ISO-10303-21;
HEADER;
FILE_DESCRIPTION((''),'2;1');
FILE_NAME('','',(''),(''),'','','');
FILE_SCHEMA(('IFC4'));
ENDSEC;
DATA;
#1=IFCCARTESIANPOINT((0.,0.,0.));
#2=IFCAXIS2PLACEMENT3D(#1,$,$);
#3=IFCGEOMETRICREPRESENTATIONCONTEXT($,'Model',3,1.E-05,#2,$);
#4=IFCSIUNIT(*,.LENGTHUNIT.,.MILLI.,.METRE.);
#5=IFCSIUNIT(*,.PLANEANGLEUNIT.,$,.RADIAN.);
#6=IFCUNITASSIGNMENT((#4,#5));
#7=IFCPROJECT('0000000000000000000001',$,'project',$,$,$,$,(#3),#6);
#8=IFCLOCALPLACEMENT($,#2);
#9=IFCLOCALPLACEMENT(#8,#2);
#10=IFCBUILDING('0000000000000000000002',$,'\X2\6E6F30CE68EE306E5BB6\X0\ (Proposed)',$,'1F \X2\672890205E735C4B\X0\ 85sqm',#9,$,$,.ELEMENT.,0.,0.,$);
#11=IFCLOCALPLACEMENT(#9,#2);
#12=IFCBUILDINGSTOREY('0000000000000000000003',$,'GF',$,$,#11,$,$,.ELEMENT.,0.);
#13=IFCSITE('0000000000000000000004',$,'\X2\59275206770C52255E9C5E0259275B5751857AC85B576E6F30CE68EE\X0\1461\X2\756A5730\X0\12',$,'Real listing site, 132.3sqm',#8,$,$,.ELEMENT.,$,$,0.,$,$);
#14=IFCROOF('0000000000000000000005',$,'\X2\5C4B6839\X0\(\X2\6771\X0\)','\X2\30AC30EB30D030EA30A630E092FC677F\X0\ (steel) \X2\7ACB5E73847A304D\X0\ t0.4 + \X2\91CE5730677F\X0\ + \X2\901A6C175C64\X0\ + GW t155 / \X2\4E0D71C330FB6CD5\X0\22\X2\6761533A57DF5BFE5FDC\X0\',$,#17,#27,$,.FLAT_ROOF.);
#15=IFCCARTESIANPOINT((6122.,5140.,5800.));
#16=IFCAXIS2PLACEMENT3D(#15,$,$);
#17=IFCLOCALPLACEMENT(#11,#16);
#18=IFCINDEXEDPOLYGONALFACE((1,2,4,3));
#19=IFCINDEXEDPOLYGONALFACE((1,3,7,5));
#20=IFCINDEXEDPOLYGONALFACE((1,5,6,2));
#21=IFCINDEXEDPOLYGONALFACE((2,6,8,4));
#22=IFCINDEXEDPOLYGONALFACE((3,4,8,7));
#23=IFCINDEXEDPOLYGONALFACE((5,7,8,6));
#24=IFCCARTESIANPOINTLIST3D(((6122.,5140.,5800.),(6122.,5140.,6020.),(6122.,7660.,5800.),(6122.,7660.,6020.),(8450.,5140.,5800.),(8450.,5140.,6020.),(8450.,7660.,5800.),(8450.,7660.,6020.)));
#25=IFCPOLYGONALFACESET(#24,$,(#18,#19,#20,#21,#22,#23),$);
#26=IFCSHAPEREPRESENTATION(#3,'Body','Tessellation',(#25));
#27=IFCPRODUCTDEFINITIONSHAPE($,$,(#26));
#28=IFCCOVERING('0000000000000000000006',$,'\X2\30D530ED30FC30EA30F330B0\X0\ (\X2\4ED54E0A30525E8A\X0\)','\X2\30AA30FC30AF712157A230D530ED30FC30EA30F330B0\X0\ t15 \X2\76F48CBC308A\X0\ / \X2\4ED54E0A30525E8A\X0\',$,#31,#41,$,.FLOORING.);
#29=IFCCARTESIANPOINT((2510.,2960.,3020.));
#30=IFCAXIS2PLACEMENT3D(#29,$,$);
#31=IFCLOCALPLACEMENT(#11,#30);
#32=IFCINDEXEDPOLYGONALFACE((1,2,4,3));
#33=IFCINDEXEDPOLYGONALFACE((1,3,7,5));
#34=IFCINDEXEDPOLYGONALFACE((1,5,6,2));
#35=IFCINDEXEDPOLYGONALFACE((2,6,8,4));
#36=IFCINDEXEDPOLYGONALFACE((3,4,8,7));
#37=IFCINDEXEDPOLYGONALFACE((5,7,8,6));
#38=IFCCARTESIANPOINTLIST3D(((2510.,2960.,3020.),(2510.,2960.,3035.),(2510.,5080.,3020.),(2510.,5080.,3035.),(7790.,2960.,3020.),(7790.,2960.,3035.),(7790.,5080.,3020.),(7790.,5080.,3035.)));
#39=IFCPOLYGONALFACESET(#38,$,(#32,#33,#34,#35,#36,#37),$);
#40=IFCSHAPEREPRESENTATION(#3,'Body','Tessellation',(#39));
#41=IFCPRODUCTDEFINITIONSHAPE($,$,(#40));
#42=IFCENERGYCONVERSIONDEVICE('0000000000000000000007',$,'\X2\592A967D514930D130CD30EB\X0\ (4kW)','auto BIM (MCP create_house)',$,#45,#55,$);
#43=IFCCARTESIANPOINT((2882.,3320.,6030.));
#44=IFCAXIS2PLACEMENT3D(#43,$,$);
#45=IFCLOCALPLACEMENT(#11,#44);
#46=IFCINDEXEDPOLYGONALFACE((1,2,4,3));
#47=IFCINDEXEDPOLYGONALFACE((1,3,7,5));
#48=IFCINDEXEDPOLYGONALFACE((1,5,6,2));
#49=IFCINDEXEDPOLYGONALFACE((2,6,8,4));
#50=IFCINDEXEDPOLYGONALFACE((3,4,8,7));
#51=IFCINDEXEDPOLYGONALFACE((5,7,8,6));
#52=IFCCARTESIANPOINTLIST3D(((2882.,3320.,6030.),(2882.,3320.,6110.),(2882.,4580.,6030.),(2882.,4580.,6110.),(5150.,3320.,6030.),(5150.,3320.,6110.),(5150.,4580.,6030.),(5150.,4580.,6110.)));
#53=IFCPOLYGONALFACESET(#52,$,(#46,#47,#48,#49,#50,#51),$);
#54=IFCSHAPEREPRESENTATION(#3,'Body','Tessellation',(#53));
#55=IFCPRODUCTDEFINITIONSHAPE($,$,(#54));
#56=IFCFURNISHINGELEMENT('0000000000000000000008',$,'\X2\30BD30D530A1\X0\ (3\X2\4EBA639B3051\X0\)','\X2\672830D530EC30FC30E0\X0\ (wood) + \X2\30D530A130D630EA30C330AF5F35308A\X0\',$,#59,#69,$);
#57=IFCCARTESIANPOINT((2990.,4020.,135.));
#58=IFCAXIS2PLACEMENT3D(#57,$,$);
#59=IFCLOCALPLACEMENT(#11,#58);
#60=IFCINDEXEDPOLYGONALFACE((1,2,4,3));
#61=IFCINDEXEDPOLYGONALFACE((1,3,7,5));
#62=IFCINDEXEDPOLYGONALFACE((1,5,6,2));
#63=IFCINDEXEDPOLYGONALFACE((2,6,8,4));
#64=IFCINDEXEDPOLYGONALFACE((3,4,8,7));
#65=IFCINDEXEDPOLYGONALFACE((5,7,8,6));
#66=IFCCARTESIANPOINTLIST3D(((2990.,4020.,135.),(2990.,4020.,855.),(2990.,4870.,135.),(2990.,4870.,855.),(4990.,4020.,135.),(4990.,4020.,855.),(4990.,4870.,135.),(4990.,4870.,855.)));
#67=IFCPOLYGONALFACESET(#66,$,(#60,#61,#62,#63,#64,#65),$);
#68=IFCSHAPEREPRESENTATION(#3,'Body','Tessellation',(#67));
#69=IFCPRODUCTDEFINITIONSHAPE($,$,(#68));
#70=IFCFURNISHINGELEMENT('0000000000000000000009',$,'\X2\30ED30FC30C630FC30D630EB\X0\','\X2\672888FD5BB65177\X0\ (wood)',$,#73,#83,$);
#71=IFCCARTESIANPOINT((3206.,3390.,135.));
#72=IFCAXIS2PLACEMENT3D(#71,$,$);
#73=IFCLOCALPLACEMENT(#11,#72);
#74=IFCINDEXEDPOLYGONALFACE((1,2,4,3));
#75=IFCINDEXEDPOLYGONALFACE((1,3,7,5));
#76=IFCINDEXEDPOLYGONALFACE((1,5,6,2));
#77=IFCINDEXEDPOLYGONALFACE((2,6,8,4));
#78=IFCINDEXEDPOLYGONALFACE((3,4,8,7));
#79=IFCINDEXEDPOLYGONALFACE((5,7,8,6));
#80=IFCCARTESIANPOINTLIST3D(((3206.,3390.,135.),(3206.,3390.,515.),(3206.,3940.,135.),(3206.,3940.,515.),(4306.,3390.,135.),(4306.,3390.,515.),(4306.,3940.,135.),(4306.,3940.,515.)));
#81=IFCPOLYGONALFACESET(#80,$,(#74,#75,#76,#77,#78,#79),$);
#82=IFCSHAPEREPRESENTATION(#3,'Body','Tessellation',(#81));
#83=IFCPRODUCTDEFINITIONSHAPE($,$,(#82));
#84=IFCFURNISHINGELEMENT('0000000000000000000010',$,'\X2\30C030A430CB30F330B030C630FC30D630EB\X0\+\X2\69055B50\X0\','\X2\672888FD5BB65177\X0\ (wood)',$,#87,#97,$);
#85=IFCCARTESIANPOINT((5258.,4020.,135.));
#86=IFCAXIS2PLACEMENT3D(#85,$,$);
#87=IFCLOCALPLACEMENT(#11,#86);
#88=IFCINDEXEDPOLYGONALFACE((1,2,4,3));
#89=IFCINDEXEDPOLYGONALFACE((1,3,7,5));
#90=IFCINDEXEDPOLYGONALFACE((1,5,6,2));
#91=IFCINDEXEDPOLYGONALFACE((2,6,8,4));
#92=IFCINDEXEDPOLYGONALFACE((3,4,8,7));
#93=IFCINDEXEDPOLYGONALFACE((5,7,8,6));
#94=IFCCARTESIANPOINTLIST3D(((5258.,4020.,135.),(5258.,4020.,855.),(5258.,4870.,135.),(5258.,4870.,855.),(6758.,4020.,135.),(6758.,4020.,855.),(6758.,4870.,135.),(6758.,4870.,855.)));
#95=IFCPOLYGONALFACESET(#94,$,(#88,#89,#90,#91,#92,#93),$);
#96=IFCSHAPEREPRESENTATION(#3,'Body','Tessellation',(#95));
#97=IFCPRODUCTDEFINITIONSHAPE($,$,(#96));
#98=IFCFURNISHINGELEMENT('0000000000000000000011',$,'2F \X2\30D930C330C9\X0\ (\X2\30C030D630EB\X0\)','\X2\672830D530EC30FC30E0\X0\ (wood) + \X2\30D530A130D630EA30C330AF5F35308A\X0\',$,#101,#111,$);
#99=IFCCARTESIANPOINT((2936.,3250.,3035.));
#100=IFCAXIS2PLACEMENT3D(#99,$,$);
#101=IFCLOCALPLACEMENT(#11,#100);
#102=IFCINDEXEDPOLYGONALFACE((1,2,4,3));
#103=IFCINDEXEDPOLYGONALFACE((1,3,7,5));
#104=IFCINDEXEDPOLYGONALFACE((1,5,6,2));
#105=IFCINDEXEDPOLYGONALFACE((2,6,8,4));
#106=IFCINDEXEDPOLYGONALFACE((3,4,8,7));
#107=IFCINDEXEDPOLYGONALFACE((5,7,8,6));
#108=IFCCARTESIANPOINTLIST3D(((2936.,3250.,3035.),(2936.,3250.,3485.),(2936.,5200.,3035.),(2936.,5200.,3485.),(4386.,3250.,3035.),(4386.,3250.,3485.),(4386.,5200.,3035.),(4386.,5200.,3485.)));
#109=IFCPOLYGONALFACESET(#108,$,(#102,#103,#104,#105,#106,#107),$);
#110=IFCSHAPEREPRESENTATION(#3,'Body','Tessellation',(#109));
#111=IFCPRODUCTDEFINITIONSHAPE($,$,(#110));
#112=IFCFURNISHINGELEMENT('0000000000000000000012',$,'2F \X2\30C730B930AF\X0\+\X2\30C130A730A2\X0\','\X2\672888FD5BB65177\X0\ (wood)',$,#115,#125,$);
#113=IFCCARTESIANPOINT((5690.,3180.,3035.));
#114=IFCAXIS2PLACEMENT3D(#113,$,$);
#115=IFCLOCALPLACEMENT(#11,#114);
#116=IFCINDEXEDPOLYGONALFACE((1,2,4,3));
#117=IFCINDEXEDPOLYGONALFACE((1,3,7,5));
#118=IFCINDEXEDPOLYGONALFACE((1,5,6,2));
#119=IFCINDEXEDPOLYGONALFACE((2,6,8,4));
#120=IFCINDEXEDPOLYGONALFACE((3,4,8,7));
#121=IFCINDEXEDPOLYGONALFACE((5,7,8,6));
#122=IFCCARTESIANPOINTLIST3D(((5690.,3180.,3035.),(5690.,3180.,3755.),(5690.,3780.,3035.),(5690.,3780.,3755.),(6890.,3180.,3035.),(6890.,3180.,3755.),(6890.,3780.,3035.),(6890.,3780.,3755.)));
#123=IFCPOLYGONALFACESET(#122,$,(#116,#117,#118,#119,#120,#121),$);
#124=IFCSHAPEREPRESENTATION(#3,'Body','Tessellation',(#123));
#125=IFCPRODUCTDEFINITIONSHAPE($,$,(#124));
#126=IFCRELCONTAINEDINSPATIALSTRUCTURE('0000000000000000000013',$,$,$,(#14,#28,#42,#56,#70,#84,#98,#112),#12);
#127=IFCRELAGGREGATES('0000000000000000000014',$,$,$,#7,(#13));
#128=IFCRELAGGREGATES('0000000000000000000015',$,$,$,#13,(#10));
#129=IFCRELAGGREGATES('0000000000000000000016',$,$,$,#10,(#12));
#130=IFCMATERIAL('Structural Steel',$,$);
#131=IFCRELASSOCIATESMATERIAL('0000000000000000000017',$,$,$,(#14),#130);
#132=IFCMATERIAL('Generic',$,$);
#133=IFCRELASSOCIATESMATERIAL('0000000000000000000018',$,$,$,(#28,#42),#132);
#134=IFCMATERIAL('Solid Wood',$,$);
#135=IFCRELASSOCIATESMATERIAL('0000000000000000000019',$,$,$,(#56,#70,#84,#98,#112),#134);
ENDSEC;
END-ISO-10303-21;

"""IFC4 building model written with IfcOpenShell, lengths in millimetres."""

from ifc_helpers import new_model, si_unit, frame, frame_2d, origin, place, context, project, spatial, rectangle, extrude, material, element, save


model = new_model("IFC4")

# Units and contexts
model_context = context("Model", 3, precision=1e-05, world=origin())
ifc_project = project(units=[si_unit("LENGTHUNIT", "METRE", prefix="MILLI"), si_unit("PLANEANGLEUNIT", "RADIAN")], contexts=[model_context])

# Site, building, storey
site_placement = place(None, origin())
site = spatial("IfcSite", under=ifc_project, at=site_placement, Name="大分県別府市大字内竈字湯ノ森1461番地12", ObjectType="Real listing site, 132.3sqm", CompositionType="ELEMENT", RefElevation=0.0)
building_placement = place(site_placement, origin())
building = spatial("IfcBuilding", under=site, at=building_placement, Name="湯ノ森の家 (Proposed)", ObjectType="1F 木造平屋 85sqm", CompositionType="ELEMENT", ElevationOfRefHeight=0.0, ElevationOfTerrain=0.0)
storey_placement = place(building_placement, origin())
storey = spatial("IfcBuildingStorey", under=building, at=storey_placement, Name="GF", CompositionType="ELEMENT", Elevation=0.0)

# Shared definitions
ifc_material_1 = material(Name="Solid Wood")

# Roof
ifc_material_2 = material(Name="Structural Steel")
roof_1_placement = place(storey_placement, frame((6122.0, 5140.0, 5800.0)))
element("IfcRoof", 1, at=roof_1_placement, inside=storey, material=ifc_material_2, Name="屋根(東)", Description="ガルバリウム鋼板 (steel) 立平葺き t0.4 + 野地板 + 通気層 + GW t155 / 不燃・法22条区域対応", PredefinedType="FLAT_ROOF", context=model_context, shape_type="SweptSolid", body=[
    extrude(rectangle(XDim=2328.0, YDim=2520.0, at=frame_2d((1164.0, 1260.0))), frame((6122.0, 5140.0, 5800.0)), (0.0, 0.0, 1.0), 220.0),
])

# Covering
ifc_material_3 = material(Name="Generic")
covering_placement = place(storey_placement, frame((2510.0, 2960.0, 3020.0)))
element("IfcCovering", 2, at=covering_placement, inside=storey, material=ifc_material_3, Name="フローリング (仕上げ床)", Description="オーク無垢フローリング t15 直貼り / 仕上げ床", PredefinedType="FLOORING", context=model_context, shape_type="SweptSolid", body=[
    extrude(rectangle(XDim=5280.0, YDim=2120.0, at=frame_2d((2640.0, 1060.0))), frame((2510.0, 2960.0, 3020.0)), (0.0, 0.0, 1.0), 15.0),
])

# Energy conversion device
energy_conversion_device_placement = place(storey_placement, frame((2882.0, 3320.0, 6030.0)))
element("IfcEnergyConversionDevice", 3, at=energy_conversion_device_placement, inside=storey, material=ifc_material_3, Name="太陽光パネル (4kW)", Description="auto BIM (MCP create_house)", context=model_context, shape_type="SweptSolid", body=[
    extrude(rectangle(XDim=2268.0, YDim=1260.0, at=frame_2d((1134.0, 630.0))), frame((2882.0, 3320.0, 6030.0)), (0.0, 0.0, 1.0), 80.0),
])

# Furnishing elements
furnishing_1_placement = place(storey_placement, frame((2990.0, 4020.0, 135.0)))
element("IfcFurnishingElement", 4, at=furnishing_1_placement, inside=storey, material=ifc_material_1, Name="ソファ (3人掛け)", Description="木フレーム (wood) + ファブリック張り", context=model_context, shape_type="SweptSolid", body=[
    extrude(rectangle(XDim=2000.0, YDim=850.0, at=frame_2d((1000.0, 425.0))), frame((2990.0, 4020.0, 135.0)), (0.0, 0.0, 1.0), 720.0),
])
furnishing_2_placement = place(storey_placement, frame((3206.0, 3390.0, 135.0)))
element("IfcFurnishingElement", 5, at=furnishing_2_placement, inside=storey, material=ifc_material_1, Name="ローテーブル", Description="木製家具 (wood)", context=model_context, shape_type="SweptSolid", body=[
    extrude(rectangle(XDim=1100.0, YDim=550.0, at=frame_2d((550.0, 275.0))), frame((3206.0, 3390.0, 135.0)), (0.0, 0.0, 1.0), 380.0),
])
furnishing_3_placement = place(storey_placement, frame((5258.0, 4020.0, 135.0)))
element("IfcFurnishingElement", 6, at=furnishing_3_placement, inside=storey, material=ifc_material_1, Name="ダイニングテーブル+椅子", Description="木製家具 (wood)", context=model_context, shape_type="SweptSolid", body=[
    extrude(rectangle(XDim=1500.0, YDim=850.0, at=frame_2d((750.0, 425.0))), frame((5258.0, 4020.0, 135.0)), (0.0, 0.0, 1.0), 720.0),
])
furnishing_4_placement = place(storey_placement, frame((2936.0, 3250.0, 3035.0)))
element("IfcFurnishingElement", 7, at=furnishing_4_placement, inside=storey, material=ifc_material_1, Name="2F ベッド (ダブル)", Description="木フレーム (wood) + ファブリック張り", context=model_context, shape_type="SweptSolid", body=[
    extrude(rectangle(XDim=1450.0, YDim=1950.0, at=frame_2d((725.0, 975.0))), frame((2936.0, 3250.0, 3035.0)), (0.0, 0.0, 1.0), 450.0),
])
furnishing_5_placement = place(storey_placement, frame((5690.0, 3180.0, 3035.0)))
element("IfcFurnishingElement", 8, at=furnishing_5_placement, inside=storey, material=ifc_material_1, Name="2F デスク+チェア", Description="木製家具 (wood)", context=model_context, shape_type="SweptSolid", body=[
    extrude(rectangle(XDim=1200.0, YDim=600.0, at=frame_2d((600.0, 300.0))), frame((5690.0, 3180.0, 3035.0)), (0.0, 0.0, 1.0), 720.0),
])

save(model, "model.ifc")
